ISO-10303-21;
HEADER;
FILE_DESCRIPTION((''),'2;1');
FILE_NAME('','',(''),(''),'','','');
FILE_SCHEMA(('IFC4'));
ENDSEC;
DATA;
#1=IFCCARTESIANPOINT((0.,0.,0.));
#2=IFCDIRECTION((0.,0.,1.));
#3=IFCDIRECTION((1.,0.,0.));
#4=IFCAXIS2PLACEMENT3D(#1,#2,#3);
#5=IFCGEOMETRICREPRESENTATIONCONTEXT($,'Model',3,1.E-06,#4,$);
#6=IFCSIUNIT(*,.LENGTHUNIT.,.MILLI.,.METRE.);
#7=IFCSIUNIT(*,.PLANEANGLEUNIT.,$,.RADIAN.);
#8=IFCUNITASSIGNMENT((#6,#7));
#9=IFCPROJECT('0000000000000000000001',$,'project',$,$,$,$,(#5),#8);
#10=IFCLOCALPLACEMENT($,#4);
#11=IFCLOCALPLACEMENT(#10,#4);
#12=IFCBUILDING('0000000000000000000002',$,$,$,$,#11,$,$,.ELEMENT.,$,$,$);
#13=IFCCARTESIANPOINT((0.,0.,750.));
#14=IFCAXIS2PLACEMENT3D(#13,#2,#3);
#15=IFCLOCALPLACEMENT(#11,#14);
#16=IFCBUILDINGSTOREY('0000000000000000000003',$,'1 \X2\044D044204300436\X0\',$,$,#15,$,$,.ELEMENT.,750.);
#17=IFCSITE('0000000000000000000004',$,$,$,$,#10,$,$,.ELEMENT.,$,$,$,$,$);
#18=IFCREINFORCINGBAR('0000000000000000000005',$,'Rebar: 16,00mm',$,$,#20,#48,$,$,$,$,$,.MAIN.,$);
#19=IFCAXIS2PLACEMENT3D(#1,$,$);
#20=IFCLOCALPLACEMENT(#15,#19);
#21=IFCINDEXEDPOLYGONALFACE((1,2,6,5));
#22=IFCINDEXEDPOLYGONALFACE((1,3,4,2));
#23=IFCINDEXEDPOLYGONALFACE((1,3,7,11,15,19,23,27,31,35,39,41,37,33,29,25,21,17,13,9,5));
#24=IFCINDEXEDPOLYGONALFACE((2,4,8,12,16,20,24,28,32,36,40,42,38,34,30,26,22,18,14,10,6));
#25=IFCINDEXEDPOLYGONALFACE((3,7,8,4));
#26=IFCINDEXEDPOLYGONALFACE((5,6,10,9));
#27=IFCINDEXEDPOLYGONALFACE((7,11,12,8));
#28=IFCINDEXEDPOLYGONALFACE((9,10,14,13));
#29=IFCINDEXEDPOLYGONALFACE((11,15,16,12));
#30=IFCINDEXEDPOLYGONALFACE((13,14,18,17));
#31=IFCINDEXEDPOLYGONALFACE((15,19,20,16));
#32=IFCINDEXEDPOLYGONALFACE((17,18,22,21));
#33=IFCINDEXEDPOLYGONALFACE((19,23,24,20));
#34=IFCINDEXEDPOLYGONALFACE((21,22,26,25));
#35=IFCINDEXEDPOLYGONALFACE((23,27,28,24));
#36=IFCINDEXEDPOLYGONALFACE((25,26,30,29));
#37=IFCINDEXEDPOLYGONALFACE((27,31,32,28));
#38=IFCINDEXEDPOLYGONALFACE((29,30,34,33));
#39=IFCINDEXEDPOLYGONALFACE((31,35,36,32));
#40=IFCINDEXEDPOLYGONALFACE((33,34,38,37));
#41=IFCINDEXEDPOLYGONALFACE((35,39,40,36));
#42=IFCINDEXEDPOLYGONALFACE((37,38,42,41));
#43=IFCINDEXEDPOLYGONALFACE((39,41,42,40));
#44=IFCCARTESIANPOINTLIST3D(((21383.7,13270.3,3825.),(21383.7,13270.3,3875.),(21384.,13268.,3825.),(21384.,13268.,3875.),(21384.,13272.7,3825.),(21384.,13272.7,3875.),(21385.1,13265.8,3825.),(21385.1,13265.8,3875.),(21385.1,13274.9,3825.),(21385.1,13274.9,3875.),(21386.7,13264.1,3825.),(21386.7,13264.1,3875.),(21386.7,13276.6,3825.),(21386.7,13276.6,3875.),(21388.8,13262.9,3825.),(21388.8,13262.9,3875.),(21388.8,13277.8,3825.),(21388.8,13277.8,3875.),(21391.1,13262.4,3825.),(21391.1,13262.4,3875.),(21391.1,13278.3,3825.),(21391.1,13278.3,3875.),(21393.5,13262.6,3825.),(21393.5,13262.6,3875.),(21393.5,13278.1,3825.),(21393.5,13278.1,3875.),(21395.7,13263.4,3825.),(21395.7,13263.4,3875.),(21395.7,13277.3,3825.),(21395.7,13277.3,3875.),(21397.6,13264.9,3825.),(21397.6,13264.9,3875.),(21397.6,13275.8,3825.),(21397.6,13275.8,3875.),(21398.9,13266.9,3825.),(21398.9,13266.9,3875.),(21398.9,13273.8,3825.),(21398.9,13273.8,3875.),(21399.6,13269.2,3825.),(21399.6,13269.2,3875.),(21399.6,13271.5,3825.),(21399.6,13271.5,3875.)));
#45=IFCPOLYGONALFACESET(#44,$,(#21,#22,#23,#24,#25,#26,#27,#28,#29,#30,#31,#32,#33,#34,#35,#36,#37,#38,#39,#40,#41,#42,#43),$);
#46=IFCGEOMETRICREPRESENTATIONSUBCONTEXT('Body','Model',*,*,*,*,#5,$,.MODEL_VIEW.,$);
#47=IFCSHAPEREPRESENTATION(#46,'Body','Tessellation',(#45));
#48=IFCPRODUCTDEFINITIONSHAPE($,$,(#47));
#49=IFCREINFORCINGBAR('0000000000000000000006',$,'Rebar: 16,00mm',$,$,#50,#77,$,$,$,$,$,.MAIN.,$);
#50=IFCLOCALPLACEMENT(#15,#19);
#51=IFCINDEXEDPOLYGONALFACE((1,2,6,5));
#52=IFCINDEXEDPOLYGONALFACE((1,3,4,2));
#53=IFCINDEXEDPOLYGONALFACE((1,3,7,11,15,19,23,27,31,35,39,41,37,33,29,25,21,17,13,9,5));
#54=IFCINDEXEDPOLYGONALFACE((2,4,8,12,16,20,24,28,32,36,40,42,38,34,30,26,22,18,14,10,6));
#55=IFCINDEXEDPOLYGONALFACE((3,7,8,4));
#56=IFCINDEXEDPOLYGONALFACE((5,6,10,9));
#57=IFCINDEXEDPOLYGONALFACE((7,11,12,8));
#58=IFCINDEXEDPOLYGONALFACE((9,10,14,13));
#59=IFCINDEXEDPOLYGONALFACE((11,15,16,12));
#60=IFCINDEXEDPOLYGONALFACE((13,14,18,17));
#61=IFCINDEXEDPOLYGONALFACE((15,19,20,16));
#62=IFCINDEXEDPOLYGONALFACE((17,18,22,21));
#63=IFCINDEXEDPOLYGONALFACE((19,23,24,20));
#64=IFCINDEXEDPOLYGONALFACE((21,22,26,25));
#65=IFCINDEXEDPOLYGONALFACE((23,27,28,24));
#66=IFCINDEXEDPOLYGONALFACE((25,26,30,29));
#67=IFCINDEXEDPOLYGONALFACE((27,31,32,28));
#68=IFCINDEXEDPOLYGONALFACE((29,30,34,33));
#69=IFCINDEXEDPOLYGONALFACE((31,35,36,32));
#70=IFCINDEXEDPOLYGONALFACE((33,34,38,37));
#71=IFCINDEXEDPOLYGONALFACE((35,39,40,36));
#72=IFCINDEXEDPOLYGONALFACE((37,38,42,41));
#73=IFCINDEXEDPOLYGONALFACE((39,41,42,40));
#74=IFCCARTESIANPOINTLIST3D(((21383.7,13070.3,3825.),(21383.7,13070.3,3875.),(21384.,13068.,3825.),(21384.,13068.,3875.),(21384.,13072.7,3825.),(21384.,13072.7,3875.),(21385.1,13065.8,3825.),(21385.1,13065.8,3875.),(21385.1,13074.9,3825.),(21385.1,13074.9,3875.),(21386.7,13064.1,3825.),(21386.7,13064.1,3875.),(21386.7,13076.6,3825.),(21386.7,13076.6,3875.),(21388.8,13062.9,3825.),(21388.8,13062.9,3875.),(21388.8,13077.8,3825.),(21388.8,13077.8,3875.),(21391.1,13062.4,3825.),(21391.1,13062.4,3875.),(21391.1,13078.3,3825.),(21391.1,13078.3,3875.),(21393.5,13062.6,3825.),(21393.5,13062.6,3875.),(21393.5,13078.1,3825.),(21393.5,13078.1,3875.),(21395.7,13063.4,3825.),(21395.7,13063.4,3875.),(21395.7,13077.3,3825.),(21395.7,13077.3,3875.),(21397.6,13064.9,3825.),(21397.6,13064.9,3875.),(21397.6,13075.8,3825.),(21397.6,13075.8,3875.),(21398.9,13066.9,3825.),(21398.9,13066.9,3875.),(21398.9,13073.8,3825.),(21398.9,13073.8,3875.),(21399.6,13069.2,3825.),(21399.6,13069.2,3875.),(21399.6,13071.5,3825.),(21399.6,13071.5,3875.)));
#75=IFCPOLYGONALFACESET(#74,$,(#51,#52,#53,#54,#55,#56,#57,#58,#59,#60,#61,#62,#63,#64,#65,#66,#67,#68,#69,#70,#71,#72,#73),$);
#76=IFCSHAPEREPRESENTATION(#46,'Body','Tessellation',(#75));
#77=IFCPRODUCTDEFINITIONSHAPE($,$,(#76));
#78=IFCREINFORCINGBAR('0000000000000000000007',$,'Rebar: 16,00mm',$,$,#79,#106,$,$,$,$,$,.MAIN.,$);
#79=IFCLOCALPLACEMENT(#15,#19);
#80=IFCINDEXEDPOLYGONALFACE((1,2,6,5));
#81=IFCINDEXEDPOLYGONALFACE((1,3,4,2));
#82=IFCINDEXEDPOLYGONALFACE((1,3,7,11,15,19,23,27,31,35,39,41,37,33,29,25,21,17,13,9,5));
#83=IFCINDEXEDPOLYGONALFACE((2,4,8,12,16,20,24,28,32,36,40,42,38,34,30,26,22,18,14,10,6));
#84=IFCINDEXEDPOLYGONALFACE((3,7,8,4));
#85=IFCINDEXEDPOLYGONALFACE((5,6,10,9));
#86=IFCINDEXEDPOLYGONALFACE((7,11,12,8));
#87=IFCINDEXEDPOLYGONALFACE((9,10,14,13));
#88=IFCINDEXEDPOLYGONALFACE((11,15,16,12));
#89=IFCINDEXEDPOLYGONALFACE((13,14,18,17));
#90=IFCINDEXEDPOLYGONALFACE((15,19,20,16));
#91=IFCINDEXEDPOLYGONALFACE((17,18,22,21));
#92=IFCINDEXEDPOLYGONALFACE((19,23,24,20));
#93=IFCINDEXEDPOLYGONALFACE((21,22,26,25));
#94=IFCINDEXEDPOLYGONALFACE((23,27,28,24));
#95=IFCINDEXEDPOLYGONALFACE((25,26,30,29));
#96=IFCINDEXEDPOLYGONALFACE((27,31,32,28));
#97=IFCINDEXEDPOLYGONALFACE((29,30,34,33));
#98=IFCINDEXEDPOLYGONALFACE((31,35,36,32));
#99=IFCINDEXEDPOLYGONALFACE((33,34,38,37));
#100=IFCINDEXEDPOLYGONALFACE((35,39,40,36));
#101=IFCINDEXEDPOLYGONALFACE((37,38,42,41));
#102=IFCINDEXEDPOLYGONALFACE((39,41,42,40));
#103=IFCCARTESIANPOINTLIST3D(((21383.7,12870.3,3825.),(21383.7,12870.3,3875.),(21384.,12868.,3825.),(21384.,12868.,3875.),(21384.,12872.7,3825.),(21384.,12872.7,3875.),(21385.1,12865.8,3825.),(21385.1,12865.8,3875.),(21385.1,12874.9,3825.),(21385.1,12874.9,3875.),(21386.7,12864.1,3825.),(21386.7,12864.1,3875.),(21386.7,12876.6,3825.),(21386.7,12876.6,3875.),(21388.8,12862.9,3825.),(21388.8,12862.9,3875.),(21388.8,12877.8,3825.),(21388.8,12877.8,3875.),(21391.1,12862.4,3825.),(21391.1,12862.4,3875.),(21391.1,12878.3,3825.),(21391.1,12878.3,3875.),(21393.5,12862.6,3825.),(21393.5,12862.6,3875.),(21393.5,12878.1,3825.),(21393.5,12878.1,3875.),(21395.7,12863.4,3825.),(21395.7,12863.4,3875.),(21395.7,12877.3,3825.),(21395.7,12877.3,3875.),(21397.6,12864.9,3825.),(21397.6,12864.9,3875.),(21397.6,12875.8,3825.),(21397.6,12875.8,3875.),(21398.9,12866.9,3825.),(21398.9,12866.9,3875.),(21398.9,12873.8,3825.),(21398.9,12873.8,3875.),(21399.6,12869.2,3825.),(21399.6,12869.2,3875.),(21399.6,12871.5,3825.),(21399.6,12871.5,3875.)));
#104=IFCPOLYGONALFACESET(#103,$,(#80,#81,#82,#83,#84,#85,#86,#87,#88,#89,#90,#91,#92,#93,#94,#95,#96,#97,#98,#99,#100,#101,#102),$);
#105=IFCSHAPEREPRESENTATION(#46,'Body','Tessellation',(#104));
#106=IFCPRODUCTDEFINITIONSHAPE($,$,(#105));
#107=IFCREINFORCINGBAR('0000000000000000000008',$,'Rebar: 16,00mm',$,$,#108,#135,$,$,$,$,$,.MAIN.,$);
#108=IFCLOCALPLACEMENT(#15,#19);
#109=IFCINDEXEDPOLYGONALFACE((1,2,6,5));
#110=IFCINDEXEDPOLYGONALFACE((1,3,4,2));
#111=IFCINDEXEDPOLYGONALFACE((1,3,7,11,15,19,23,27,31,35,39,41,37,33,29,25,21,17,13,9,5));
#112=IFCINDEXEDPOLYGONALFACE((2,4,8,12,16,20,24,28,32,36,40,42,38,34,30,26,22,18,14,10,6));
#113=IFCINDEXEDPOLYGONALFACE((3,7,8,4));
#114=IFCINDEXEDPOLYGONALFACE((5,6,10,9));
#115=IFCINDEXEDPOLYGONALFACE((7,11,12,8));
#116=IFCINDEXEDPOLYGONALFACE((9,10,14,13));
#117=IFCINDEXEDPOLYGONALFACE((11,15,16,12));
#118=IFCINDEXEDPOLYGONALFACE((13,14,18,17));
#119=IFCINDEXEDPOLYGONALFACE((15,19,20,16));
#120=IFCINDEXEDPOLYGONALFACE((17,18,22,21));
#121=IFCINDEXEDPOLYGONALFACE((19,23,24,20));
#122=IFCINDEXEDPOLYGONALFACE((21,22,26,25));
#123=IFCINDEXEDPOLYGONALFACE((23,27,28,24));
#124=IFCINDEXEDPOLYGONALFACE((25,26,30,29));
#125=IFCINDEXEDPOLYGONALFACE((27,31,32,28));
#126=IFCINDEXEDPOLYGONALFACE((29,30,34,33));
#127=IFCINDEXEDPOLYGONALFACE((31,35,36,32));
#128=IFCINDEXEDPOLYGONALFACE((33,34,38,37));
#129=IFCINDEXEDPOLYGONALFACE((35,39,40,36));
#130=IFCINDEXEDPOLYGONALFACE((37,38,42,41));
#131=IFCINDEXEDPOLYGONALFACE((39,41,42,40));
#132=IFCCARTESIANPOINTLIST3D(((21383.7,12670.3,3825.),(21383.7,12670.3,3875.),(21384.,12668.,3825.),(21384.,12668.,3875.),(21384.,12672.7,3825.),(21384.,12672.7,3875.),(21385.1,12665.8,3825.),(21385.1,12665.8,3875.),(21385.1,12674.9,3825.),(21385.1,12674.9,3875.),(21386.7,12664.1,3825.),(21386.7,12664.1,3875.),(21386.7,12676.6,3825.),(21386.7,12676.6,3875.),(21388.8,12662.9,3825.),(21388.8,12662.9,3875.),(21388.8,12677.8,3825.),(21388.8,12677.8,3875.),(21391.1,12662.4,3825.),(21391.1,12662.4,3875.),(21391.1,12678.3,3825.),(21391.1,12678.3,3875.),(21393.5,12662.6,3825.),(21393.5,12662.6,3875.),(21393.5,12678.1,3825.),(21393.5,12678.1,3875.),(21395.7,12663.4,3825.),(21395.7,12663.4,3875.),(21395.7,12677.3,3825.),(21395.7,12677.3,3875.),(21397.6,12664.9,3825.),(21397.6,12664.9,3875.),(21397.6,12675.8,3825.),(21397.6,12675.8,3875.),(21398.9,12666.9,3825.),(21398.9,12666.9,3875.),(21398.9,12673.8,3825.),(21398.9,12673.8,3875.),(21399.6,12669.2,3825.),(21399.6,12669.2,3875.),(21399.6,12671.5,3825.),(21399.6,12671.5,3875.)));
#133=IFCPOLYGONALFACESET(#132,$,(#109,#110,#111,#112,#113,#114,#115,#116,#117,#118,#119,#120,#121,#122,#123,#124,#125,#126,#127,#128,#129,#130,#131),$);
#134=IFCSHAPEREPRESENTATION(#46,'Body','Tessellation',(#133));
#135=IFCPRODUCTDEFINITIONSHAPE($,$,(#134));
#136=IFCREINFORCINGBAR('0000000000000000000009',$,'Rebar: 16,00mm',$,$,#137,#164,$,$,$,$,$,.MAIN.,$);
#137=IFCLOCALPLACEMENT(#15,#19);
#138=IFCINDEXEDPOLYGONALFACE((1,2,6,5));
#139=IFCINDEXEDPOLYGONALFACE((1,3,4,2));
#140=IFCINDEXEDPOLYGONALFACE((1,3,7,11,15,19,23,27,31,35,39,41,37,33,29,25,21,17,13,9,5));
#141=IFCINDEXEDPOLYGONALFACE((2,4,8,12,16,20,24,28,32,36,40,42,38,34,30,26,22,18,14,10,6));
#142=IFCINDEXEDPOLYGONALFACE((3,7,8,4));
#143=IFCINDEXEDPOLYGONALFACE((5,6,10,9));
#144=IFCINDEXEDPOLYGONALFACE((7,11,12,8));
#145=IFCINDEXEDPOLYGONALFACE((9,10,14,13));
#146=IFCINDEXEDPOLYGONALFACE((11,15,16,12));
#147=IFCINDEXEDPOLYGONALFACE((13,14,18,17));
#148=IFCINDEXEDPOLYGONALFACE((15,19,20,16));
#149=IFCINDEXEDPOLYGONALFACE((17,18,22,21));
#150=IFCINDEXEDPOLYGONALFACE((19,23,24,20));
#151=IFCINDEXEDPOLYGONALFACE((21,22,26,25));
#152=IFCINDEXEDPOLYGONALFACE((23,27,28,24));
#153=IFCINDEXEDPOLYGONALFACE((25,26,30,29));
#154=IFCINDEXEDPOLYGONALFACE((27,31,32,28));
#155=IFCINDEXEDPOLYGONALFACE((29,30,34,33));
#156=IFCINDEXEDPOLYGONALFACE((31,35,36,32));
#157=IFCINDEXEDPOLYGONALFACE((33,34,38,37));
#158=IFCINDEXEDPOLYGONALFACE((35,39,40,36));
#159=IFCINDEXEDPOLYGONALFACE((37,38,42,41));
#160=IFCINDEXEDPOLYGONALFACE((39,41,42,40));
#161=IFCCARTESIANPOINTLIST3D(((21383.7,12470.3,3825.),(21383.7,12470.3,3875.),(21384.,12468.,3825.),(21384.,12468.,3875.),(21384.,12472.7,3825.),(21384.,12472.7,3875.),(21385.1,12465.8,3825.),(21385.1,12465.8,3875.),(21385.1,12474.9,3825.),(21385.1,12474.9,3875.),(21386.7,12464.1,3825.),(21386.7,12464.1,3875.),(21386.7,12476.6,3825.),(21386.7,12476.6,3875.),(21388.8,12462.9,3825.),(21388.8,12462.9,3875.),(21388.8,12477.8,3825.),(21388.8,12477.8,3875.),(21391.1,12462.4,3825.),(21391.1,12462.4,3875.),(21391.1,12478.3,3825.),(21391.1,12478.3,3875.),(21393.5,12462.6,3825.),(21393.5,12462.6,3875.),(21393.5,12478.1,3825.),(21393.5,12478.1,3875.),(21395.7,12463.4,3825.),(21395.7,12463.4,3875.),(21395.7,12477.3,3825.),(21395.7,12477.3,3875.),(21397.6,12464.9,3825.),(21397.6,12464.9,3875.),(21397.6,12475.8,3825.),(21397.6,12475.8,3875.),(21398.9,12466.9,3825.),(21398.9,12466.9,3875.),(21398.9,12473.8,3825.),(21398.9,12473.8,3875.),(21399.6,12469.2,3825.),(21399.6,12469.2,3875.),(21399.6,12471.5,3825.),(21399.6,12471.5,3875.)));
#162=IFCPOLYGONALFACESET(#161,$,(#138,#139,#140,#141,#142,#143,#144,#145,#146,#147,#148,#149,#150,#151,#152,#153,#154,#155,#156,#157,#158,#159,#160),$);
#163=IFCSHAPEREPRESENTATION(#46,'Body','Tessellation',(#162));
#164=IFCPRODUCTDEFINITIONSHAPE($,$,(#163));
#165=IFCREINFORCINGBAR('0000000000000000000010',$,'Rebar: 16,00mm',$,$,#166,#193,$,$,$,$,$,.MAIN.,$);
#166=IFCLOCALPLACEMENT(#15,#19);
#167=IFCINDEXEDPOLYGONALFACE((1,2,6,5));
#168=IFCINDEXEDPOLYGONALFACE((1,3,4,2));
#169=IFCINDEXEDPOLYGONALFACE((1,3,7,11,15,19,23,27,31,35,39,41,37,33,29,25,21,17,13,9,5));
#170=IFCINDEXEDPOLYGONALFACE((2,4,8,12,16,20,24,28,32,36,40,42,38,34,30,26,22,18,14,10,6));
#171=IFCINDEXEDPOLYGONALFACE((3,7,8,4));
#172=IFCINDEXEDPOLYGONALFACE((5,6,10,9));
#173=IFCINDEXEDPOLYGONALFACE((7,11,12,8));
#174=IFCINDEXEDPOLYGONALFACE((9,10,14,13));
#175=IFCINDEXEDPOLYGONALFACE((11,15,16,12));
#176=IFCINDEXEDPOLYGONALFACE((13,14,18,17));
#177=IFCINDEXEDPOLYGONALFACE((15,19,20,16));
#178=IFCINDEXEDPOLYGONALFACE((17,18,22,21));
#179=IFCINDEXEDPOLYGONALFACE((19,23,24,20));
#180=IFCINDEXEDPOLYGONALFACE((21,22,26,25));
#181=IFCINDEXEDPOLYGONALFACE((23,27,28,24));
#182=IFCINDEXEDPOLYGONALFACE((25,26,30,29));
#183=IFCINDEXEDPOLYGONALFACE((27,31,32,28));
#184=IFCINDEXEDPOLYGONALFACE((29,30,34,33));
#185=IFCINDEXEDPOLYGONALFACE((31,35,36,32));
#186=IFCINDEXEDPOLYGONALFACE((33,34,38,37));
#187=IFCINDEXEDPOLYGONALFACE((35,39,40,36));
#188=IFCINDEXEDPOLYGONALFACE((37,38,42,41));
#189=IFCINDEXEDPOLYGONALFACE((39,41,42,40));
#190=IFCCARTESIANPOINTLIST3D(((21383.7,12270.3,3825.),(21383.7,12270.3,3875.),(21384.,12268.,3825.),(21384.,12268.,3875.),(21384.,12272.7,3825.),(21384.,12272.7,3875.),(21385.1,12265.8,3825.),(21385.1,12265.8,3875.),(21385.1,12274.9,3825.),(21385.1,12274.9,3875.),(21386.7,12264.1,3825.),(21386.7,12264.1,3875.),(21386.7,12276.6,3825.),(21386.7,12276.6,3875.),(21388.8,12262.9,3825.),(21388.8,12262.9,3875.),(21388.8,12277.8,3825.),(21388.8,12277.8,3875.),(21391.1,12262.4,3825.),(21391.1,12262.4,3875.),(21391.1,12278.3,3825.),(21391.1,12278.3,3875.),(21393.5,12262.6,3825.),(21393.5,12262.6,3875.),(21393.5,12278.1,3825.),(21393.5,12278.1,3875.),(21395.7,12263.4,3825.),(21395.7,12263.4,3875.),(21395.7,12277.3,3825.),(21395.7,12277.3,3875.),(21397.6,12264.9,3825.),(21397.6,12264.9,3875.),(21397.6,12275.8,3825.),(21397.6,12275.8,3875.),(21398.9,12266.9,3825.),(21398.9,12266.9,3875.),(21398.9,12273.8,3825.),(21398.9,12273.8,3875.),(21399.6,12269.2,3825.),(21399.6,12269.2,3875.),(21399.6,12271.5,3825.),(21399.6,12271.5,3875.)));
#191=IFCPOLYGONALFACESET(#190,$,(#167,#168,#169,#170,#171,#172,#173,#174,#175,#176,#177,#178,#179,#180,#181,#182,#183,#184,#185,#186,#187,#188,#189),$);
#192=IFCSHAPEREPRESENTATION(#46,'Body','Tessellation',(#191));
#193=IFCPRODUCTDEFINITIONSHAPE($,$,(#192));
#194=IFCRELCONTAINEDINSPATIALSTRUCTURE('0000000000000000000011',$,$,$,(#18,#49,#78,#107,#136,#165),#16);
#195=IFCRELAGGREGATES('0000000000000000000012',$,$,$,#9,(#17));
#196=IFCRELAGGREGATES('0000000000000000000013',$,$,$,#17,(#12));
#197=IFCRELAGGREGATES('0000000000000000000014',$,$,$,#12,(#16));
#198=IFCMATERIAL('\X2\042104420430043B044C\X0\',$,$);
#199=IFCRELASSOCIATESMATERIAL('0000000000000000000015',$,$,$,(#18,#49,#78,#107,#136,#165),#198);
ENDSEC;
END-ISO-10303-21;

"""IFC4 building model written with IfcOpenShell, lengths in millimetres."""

from ifc_helpers import new_model, entity, si_unit, frame, origin_with_axes, place, context, subcontext, project, spatial, source, transform, mapped, material, element, save


model = new_model("IFC4")

# Units and contexts
model_context = context("Model", 3, precision=1e-06, world=origin_with_axes())
body_context = subcontext(model_context, "Body", "Model", "MODEL_VIEW")
ifc_project = project(units=[si_unit("LENGTHUNIT", "METRE", prefix="MILLI"), si_unit("PLANEANGLEUNIT", "RADIAN")], contexts=[model_context])

# Site, building, storey
site_placement = place(None, origin_with_axes())
site = spatial("IfcSite", under=ifc_project, at=site_placement, CompositionType="ELEMENT")
building_placement = place(site_placement, origin_with_axes())
building = spatial("IfcBuilding", under=site, at=building_placement, CompositionType="ELEMENT")
storey_placement = place(building_placement, frame((0.0, 0.0, 750.0), z_axis=(0.0, 0.0, 1.0), x_axis=(1.0, 0.0, 0.0)))
storey = spatial("IfcBuildingStorey", under=building, at=storey_placement, Name="1 этаж", CompositionType="ELEMENT", Elevation=750.0)

# Reinforcing bars
ifc_material = material(Name="Сталь")
shared_shape_1 = source(origin_with_axes(), body_context, "Body", "AdvancedSweptSolid", [
    entity("IfcSweptDiskSolid", entity("IfcIndexedPolyCurve", entity("IfcCartesianPointList3D", [[0.0, 0.0, 0.0], [50.0, 0.0, 0.0]]), [entity("IfcLineIndex", [1, 2])]), 8.0),
])
reinforcing_bar_1_placement = place(storey_placement, origin_with_axes())
element("IfcReinforcingBar", 1, at=reinforcing_bar_1_placement, inside=storey, material=ifc_material, Name="Rebar: 16,00mm", PredefinedType="MAIN", context=body_context, shape_type="MappedRepresentation", body=[
    mapped(shared_shape_1, transform((21391.7, 13270.3, 3825.0), x_axis=(0.0, 0.0, 1.0), y_axis=(0.0, 1.0, 0.0), z_axis=(-1.0, 0.0, 0.0), scale=1.0)),
])
reinforcing_bar_2_placement = place(storey_placement, origin_with_axes())
element("IfcReinforcingBar", 2, at=reinforcing_bar_2_placement, inside=storey, material=ifc_material, Name="Rebar: 16,00mm", PredefinedType="MAIN", context=body_context, shape_type="MappedRepresentation", body=[
    mapped(shared_shape_1, transform((21391.7, 13070.3, 3825.0), x_axis=(0.0, 0.0, 1.0), y_axis=(0.0, 1.0, 0.0), z_axis=(-1.0, 0.0, 0.0), scale=1.0)),
])
reinforcing_bar_3_placement = place(storey_placement, origin_with_axes())
element("IfcReinforcingBar", 3, at=reinforcing_bar_3_placement, inside=storey, material=ifc_material, Name="Rebar: 16,00mm", PredefinedType="MAIN", context=body_context, shape_type="MappedRepresentation", body=[
    mapped(shared_shape_1, transform((21391.7, 12870.3, 3825.0), x_axis=(0.0, 0.0, 1.0), y_axis=(0.0, 1.0, 0.0), z_axis=(-1.0, 0.0, 0.0), scale=1.0)),
])
reinforcing_bar_4_placement = place(storey_placement, origin_with_axes())
element("IfcReinforcingBar", 4, at=reinforcing_bar_4_placement, inside=storey, material=ifc_material, Name="Rebar: 16,00mm", PredefinedType="MAIN", context=body_context, shape_type="MappedRepresentation", body=[
    mapped(shared_shape_1, transform((21391.7, 12670.3, 3825.0), x_axis=(0.0, 0.0, 1.0), y_axis=(0.0, 1.0, 0.0), z_axis=(-1.0, 0.0, 0.0), scale=1.0)),
])
reinforcing_bar_5_placement = place(storey_placement, origin_with_axes())
element("IfcReinforcingBar", 5, at=reinforcing_bar_5_placement, inside=storey, material=ifc_material, Name="Rebar: 16,00mm", PredefinedType="MAIN", context=body_context, shape_type="MappedRepresentation", body=[
    mapped(shared_shape_1, transform((21391.7, 12470.3, 3825.0), x_axis=(0.0, 0.0, 1.0), y_axis=(0.0, 1.0, 0.0), z_axis=(-1.0, 0.0, 0.0), scale=1.0)),
])
reinforcing_bar_6_placement = place(storey_placement, origin_with_axes())
element("IfcReinforcingBar", 6, at=reinforcing_bar_6_placement, inside=storey, material=ifc_material, Name="Rebar: 16,00mm", PredefinedType="MAIN", context=body_context, shape_type="MappedRepresentation", body=[
    mapped(shared_shape_1, transform((21391.7, 12270.3, 3825.0), x_axis=(0.0, 0.0, 1.0), y_axis=(0.0, 1.0, 0.0), z_axis=(-1.0, 0.0, 0.0), scale=1.0)),
])

save(model, "model.ifc")
